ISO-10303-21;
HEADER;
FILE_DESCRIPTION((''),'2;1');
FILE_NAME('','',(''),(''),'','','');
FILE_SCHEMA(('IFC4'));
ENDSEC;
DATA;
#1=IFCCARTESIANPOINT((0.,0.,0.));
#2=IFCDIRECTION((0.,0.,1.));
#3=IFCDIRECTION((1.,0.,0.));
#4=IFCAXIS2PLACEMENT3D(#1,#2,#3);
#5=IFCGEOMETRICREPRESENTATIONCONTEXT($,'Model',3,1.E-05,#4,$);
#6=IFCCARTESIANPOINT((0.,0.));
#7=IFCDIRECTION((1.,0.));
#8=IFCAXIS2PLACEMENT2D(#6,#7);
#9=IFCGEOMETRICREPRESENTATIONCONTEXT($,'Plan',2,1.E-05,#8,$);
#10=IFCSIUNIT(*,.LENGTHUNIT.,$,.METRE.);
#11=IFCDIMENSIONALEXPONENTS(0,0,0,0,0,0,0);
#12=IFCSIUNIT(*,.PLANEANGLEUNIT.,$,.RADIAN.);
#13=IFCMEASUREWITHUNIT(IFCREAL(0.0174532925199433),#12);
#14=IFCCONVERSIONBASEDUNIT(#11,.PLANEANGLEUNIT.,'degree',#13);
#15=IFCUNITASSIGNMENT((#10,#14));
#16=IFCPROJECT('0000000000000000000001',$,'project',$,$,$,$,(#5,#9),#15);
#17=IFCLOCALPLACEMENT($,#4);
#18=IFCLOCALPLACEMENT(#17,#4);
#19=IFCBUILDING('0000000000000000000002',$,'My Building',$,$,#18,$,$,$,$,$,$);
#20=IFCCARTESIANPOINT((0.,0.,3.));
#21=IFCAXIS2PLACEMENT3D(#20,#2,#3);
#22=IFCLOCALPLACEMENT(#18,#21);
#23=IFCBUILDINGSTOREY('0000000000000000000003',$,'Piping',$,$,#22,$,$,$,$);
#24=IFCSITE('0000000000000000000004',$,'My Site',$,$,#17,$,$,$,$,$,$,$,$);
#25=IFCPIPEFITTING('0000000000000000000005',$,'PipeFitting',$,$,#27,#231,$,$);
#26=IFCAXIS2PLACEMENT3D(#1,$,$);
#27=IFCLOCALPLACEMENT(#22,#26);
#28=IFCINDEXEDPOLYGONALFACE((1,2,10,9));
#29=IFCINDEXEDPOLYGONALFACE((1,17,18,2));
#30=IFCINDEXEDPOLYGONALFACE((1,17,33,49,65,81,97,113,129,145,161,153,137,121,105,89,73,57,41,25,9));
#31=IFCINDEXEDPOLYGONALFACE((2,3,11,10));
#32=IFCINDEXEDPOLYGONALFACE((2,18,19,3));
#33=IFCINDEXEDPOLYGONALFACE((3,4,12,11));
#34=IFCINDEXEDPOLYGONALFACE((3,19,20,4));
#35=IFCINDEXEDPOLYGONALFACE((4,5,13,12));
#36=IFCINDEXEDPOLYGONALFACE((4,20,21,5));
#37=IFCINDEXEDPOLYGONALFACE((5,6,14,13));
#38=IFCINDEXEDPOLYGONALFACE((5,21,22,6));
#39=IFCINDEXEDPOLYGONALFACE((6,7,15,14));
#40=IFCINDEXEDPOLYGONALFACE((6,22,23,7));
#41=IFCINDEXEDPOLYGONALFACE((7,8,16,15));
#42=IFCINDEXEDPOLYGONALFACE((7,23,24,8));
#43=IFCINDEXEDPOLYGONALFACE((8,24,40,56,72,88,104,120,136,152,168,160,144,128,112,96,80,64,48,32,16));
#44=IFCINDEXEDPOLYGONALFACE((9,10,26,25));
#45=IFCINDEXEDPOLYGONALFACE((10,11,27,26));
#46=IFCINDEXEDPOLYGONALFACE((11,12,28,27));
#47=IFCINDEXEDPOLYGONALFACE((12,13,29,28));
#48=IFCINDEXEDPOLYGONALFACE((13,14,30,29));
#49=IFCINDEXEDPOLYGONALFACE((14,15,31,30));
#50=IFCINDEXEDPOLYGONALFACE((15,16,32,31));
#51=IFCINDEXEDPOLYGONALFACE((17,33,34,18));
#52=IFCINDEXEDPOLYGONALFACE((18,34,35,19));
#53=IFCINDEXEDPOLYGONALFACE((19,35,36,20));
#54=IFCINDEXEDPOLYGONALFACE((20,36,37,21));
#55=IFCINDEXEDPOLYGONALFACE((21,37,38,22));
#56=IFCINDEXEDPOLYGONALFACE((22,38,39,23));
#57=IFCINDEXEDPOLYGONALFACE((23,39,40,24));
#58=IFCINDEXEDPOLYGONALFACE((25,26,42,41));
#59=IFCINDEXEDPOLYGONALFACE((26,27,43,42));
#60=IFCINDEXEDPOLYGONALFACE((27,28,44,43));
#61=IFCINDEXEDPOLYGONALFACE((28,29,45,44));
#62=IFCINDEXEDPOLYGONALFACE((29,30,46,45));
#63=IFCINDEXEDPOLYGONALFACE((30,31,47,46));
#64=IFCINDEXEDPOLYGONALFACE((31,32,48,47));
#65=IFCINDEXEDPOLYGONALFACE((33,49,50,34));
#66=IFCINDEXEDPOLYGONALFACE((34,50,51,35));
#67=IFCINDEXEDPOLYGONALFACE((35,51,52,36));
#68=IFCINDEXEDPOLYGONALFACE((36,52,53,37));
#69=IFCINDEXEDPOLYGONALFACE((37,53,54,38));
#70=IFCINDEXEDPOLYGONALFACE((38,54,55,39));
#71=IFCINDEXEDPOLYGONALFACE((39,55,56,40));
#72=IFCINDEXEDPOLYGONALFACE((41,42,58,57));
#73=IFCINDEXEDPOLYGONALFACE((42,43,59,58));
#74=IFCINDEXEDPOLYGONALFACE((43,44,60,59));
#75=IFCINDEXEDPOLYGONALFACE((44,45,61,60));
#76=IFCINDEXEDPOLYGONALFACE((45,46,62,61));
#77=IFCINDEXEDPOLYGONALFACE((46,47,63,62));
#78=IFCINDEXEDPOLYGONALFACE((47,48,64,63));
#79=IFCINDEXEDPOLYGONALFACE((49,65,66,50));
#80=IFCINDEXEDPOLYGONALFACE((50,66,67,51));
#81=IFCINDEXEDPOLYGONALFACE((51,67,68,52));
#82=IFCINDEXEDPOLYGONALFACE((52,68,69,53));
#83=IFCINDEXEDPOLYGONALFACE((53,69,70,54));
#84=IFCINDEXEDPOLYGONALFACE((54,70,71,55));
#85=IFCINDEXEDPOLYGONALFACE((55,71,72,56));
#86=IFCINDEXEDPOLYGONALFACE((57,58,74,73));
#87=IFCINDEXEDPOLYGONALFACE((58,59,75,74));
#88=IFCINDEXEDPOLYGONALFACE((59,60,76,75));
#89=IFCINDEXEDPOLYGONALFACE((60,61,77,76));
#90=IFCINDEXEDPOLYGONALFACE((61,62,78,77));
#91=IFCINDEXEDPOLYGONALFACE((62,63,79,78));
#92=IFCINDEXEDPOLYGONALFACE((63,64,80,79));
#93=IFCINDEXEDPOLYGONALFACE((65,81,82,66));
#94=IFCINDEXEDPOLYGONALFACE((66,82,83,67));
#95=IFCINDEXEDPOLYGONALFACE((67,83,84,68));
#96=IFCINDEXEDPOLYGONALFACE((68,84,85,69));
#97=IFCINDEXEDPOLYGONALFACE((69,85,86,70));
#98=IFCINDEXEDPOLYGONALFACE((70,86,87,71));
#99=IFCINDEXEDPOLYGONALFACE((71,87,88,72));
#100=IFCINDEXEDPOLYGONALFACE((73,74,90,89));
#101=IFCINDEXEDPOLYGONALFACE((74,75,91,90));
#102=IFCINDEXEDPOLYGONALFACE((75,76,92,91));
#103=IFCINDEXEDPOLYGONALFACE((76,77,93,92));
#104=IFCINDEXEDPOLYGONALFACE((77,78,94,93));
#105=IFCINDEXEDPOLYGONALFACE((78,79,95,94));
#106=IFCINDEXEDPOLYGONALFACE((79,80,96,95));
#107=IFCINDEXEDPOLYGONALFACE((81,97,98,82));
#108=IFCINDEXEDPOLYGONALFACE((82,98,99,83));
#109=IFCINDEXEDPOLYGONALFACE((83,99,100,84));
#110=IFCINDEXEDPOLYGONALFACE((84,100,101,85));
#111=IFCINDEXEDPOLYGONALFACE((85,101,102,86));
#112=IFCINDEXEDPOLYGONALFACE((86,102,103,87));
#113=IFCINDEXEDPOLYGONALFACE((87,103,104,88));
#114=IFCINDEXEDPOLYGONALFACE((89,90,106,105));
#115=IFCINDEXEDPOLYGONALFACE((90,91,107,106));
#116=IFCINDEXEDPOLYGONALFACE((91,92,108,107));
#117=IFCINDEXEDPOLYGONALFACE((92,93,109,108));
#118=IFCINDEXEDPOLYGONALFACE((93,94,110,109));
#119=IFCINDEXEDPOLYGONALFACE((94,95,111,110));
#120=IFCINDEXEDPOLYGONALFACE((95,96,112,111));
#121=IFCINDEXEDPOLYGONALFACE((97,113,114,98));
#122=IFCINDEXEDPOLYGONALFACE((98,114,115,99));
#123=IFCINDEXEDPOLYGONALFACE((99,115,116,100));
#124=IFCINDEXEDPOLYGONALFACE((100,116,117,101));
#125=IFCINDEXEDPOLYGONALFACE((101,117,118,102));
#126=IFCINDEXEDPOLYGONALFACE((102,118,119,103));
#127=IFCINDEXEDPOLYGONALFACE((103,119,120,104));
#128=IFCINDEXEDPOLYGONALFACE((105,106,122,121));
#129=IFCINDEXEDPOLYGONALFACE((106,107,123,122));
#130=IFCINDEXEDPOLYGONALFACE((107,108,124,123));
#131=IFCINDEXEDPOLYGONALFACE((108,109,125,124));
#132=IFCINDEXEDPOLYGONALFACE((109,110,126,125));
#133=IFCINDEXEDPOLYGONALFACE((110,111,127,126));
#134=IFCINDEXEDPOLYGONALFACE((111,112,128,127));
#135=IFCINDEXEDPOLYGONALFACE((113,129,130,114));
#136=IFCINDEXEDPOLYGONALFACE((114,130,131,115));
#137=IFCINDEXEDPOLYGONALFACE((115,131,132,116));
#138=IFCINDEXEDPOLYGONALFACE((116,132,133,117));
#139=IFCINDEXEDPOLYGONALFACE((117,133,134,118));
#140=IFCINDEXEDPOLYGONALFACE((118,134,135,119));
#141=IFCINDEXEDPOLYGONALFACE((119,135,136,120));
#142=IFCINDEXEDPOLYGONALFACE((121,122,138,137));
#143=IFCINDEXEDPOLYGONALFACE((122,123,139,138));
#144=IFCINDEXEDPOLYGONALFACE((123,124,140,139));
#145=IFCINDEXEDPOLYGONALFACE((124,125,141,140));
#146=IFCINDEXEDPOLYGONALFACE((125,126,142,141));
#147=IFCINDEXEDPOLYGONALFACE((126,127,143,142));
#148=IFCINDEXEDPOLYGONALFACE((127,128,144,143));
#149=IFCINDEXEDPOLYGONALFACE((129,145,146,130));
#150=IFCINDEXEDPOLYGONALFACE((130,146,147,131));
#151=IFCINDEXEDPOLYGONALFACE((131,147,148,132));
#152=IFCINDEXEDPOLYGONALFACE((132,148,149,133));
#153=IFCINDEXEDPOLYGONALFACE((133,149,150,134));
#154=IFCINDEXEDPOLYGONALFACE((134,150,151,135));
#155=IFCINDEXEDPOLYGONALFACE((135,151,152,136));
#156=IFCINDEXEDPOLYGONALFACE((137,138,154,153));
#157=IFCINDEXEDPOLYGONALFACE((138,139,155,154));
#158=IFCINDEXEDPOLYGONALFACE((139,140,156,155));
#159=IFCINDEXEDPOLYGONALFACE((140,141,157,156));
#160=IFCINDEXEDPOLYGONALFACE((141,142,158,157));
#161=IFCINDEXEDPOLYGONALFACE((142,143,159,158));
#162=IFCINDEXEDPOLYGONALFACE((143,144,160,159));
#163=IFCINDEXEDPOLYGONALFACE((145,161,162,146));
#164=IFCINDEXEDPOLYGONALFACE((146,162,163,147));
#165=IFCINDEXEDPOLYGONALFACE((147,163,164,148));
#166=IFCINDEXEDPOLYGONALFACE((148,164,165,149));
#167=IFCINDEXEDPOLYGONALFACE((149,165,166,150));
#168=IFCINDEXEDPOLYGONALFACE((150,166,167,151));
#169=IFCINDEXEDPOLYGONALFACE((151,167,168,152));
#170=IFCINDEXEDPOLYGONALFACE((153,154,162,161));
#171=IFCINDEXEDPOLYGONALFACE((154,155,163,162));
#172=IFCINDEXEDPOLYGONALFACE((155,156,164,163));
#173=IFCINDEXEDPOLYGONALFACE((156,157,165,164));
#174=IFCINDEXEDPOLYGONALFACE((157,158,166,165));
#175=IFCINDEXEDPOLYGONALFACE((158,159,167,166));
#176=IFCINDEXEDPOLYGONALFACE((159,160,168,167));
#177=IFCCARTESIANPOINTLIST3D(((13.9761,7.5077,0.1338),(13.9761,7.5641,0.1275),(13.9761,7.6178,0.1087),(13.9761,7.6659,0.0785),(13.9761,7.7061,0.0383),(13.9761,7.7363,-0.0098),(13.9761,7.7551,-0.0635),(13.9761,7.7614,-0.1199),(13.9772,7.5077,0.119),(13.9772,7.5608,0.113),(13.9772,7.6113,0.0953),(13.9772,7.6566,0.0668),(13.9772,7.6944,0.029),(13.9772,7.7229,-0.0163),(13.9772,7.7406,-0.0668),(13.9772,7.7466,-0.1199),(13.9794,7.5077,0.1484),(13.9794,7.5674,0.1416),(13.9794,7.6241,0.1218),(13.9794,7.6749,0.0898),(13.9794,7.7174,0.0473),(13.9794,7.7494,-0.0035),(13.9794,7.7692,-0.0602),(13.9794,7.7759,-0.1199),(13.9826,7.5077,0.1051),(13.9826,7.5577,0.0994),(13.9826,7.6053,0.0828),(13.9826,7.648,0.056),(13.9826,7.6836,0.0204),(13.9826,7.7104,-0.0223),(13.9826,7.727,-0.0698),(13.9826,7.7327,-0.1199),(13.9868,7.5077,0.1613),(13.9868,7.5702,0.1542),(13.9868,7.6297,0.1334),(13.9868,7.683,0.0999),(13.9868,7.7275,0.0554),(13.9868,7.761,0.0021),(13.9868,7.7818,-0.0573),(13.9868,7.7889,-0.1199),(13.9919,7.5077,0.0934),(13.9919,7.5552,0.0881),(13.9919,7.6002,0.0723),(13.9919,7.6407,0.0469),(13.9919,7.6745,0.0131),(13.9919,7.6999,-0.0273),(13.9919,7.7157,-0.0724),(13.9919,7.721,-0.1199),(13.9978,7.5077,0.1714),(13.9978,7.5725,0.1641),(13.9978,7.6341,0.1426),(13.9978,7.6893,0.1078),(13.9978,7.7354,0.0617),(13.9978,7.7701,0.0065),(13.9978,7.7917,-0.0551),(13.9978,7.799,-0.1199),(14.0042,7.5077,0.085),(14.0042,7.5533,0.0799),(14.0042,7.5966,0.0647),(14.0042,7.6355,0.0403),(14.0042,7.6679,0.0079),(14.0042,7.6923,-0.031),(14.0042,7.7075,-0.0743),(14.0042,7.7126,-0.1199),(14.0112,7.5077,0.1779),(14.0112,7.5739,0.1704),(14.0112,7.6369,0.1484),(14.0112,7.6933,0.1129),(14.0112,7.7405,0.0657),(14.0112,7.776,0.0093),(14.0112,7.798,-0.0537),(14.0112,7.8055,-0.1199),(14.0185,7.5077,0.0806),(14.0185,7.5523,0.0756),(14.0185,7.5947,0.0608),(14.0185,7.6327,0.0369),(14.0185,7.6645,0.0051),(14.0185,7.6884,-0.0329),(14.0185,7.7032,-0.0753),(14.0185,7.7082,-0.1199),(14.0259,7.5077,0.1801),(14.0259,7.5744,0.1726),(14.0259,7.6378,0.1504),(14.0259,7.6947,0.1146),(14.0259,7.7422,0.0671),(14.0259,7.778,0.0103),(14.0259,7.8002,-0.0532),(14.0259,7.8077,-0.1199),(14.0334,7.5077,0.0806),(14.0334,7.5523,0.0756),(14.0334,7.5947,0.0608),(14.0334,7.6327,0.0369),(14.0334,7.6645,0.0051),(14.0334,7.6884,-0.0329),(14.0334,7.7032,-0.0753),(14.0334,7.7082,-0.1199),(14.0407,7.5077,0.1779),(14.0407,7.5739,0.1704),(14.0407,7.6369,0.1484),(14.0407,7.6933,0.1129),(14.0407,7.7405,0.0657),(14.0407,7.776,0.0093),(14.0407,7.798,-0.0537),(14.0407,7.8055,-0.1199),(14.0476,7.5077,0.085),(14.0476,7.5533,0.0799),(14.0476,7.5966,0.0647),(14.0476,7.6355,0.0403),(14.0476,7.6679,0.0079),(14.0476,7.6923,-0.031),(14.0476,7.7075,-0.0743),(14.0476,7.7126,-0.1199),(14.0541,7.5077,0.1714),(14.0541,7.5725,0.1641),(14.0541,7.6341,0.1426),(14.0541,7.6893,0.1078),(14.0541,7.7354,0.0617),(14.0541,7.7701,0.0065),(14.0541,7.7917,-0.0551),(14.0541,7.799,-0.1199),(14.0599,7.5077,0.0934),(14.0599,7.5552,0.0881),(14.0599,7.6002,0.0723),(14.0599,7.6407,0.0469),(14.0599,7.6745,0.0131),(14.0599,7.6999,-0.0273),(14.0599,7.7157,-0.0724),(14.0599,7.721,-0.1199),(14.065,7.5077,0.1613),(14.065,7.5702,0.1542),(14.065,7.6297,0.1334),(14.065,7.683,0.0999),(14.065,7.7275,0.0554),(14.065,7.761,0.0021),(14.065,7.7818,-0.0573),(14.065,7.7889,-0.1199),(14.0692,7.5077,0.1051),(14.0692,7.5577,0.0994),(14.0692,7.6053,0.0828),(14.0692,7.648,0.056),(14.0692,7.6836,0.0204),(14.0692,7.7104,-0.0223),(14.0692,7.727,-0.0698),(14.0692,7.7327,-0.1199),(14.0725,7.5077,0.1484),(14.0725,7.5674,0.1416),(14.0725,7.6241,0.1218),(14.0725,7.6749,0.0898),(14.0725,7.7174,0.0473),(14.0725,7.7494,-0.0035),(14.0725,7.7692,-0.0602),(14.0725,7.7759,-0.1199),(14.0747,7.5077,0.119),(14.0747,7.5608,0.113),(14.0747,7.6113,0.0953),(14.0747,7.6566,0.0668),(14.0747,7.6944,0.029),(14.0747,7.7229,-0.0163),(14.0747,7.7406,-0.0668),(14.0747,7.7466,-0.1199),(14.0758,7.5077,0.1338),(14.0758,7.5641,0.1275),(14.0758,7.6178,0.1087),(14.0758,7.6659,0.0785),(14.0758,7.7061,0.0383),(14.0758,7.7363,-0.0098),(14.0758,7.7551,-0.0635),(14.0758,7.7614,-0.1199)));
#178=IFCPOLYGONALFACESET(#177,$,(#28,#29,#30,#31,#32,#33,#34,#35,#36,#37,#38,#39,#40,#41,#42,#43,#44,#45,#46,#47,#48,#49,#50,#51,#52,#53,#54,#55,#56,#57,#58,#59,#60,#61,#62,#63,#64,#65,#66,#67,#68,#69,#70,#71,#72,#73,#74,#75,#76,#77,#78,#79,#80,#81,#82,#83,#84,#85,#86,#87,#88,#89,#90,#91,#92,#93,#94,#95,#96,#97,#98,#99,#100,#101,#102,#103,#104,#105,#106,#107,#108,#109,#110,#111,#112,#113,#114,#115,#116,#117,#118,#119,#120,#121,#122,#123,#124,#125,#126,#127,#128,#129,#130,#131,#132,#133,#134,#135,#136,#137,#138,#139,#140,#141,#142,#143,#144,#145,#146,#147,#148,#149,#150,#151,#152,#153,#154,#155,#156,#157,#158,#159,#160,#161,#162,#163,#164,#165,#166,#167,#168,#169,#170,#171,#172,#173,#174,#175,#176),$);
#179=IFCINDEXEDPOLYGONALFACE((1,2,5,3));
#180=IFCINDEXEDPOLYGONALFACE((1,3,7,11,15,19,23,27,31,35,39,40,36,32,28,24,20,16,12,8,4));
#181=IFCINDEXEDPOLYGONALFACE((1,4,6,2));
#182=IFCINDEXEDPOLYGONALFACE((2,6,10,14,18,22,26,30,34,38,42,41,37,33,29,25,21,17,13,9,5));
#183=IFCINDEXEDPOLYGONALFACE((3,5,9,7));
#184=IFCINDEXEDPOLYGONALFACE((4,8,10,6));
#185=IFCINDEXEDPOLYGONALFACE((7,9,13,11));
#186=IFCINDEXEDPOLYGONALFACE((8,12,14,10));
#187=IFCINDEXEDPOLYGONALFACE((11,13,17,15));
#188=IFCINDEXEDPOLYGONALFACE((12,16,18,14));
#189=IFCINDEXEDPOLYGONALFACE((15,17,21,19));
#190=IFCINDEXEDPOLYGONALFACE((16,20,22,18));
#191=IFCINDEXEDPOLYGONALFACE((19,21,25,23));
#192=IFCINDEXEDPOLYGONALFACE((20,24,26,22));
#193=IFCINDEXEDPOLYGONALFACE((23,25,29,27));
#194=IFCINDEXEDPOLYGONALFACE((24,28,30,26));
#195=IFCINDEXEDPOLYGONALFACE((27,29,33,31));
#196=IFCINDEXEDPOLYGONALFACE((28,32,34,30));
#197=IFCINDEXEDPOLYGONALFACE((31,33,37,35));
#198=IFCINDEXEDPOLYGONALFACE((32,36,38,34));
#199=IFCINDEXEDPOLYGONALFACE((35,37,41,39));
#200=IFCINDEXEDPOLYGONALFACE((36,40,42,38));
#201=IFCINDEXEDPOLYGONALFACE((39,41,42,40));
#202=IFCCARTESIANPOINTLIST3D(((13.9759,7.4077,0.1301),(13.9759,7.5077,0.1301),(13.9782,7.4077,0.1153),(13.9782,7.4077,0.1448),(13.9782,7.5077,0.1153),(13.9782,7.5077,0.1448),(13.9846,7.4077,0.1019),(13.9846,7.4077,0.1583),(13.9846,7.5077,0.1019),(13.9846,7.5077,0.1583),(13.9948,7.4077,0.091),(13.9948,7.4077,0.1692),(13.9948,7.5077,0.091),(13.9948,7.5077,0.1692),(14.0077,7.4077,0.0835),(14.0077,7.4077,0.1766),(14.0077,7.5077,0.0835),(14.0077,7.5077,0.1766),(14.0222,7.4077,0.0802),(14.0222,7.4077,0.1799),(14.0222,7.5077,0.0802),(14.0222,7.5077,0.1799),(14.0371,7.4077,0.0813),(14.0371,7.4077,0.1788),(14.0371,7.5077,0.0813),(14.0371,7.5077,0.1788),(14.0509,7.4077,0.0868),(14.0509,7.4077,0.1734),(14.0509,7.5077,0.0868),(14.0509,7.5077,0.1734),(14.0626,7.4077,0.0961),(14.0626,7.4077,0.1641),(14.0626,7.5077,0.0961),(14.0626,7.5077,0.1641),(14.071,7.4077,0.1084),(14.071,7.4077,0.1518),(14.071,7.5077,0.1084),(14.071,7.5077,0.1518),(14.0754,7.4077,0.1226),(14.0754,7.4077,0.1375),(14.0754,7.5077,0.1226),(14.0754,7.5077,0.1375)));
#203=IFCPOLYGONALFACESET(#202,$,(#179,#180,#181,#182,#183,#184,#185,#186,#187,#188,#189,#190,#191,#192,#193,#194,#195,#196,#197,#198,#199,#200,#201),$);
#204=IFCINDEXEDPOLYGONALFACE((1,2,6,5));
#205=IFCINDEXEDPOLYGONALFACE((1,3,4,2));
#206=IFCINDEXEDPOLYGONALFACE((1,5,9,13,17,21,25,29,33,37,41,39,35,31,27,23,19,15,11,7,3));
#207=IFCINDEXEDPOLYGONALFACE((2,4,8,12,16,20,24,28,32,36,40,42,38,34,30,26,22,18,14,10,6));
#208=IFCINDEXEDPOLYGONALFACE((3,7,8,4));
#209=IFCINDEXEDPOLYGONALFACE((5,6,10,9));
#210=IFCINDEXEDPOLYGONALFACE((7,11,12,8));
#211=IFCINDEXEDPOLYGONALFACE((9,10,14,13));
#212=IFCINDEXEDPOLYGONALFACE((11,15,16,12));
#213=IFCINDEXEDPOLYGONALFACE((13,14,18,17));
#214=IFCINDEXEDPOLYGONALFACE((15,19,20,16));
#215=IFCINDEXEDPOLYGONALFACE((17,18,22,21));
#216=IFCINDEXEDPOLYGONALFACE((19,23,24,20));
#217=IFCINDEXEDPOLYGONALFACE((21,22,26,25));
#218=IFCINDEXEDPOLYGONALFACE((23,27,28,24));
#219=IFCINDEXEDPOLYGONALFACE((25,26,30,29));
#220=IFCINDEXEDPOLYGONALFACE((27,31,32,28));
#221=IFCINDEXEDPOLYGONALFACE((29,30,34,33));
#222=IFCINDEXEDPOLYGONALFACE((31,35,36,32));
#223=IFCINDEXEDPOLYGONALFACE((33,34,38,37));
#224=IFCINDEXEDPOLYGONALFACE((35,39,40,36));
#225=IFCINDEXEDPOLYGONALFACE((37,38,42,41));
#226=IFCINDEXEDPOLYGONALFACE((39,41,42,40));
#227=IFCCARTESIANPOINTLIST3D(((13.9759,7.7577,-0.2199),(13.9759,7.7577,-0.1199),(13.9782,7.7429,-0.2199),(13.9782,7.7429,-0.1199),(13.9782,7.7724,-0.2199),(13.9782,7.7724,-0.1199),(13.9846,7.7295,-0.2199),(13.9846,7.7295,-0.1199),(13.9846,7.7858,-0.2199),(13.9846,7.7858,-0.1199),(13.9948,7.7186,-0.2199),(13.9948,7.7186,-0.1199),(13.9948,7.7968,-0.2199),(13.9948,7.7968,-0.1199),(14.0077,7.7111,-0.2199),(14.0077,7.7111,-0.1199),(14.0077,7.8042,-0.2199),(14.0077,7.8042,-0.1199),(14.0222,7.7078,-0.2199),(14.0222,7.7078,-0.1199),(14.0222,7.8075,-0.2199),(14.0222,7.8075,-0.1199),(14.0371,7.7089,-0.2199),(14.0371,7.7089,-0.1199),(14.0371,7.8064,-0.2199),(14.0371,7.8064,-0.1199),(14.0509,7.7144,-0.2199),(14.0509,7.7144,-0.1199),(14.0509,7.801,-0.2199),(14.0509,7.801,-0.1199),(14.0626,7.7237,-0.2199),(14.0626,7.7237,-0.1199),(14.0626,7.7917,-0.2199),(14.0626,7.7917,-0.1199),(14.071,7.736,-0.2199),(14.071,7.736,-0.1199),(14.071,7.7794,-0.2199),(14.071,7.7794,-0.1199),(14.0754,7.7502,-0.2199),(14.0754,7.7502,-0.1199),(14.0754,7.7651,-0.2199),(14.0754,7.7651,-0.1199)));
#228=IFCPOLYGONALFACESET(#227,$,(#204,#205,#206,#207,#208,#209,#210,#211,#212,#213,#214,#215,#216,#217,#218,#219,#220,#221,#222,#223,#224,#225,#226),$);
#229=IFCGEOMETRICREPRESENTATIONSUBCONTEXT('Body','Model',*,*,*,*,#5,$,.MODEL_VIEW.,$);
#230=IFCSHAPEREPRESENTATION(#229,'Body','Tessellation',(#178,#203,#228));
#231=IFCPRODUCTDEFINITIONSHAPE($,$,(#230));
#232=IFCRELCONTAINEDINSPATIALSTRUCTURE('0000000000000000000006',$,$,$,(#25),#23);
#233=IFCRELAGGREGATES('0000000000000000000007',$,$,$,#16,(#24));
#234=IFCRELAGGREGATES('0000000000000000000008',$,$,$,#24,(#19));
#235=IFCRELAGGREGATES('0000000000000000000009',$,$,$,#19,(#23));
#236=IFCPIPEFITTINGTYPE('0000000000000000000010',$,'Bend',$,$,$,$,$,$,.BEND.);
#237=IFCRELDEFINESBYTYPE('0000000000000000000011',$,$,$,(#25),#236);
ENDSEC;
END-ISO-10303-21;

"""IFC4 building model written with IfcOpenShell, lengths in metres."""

from ifc_helpers import new_model, entity, si_unit, converted_unit, frame, origin_with_axes, origin_2d_with_axis, place, context, subcontext, project, spatial, circle, extrude, source, transform, mapped, type_object, type_shapes, element, save


model = new_model("IFC4")

# Units and contexts
model_context = context("Model", 3, precision=1e-05, world=origin_with_axes())
plan_context = context("Plan", 2, precision=1e-05, world=origin_2d_with_axis())
body_context = subcontext(model_context, "Body", "Model", "MODEL_VIEW")
ifc_project = project(units=[si_unit("LENGTHUNIT", "METRE"), converted_unit("PLANEANGLEUNIT", "degree", entity("IfcReal", 0.0174532925199433), si_unit("PLANEANGLEUNIT", "RADIAN"), dimensions=[0, 0, 0, 0, 0, 0, 0])], contexts=[model_context, plan_context])

# Site, building, storey
site_placement = place(None, origin_with_axes())
site = spatial("IfcSite", under=ifc_project, at=site_placement, Name="My Site")
building_placement = place(site_placement, origin_with_axes())
building = spatial("IfcBuilding", under=site, at=building_placement, Name="My Building")
storey_placement = place(building_placement, frame((0.0, 0.0, 3.0), z_axis=(0.0, 0.0, 1.0), x_axis=(1.0, 0.0, 0.0)))
storey = spatial("IfcBuildingStorey", under=building, at=storey_placement, Name="Piping")

# Pipe fitting
pipe_fitting_type_1 = type_object("IfcPipeFittingType", Name="Bend", PredefinedType="BEND")
shared_shape_1 = source(origin_with_axes(), body_context, "Body", "SolidModel", [
    entity("IfcSweptDiskSolid", entity("IfcIndexedPolyCurve", entity("IfcCartesianPointList3D", [[0.0, 0.0, 0.1], [0.0, -0.0732, 0.2768], [0.0, -0.25, 0.35]]), [entity("IfcArcIndex", [1, 2, 3])]), 0.05),
    extrude(circle(Radius=0.05), origin_with_axes(), (0.0, 0.0, 1.0), 0.1),
    extrude(circle(Radius=0.05), frame((0.0, -0.25, 0.35), z_axis=(0.0, -1.0, -0.000015), x_axis=(1.0, 0.0, 0.0)), (0.0, 0.0, 1.0), 0.1),
])
type_shapes(pipe_fitting_type_1, [shared_shape_1])
for number, where, z_axis, x_axis, name in (
    (1, (14.0259, 7.4077, 0.1301), (0.0, 1.0, 0.000015), (-1.0, 0.0, 0.0), "PipeFitting"),
):
    element("IfcPipeFitting", number, at=place(storey_placement, frame(where, z_axis=z_axis, x_axis=x_axis)), inside=storey, type_object=pipe_fitting_type_1, Name=name, context=body_context, shape_type="MappedRepresentation", body=[
        mapped(shared_shape_1, transform((0.0, 0.0, 0.0), x_axis=(1.0, 0.0, 0.0), y_axis=(0.0, 1.0, 0.0), z_axis=(0.0, 0.0, 1.0), scale=1.0)),
    ])

save(model, "model.ifc")
